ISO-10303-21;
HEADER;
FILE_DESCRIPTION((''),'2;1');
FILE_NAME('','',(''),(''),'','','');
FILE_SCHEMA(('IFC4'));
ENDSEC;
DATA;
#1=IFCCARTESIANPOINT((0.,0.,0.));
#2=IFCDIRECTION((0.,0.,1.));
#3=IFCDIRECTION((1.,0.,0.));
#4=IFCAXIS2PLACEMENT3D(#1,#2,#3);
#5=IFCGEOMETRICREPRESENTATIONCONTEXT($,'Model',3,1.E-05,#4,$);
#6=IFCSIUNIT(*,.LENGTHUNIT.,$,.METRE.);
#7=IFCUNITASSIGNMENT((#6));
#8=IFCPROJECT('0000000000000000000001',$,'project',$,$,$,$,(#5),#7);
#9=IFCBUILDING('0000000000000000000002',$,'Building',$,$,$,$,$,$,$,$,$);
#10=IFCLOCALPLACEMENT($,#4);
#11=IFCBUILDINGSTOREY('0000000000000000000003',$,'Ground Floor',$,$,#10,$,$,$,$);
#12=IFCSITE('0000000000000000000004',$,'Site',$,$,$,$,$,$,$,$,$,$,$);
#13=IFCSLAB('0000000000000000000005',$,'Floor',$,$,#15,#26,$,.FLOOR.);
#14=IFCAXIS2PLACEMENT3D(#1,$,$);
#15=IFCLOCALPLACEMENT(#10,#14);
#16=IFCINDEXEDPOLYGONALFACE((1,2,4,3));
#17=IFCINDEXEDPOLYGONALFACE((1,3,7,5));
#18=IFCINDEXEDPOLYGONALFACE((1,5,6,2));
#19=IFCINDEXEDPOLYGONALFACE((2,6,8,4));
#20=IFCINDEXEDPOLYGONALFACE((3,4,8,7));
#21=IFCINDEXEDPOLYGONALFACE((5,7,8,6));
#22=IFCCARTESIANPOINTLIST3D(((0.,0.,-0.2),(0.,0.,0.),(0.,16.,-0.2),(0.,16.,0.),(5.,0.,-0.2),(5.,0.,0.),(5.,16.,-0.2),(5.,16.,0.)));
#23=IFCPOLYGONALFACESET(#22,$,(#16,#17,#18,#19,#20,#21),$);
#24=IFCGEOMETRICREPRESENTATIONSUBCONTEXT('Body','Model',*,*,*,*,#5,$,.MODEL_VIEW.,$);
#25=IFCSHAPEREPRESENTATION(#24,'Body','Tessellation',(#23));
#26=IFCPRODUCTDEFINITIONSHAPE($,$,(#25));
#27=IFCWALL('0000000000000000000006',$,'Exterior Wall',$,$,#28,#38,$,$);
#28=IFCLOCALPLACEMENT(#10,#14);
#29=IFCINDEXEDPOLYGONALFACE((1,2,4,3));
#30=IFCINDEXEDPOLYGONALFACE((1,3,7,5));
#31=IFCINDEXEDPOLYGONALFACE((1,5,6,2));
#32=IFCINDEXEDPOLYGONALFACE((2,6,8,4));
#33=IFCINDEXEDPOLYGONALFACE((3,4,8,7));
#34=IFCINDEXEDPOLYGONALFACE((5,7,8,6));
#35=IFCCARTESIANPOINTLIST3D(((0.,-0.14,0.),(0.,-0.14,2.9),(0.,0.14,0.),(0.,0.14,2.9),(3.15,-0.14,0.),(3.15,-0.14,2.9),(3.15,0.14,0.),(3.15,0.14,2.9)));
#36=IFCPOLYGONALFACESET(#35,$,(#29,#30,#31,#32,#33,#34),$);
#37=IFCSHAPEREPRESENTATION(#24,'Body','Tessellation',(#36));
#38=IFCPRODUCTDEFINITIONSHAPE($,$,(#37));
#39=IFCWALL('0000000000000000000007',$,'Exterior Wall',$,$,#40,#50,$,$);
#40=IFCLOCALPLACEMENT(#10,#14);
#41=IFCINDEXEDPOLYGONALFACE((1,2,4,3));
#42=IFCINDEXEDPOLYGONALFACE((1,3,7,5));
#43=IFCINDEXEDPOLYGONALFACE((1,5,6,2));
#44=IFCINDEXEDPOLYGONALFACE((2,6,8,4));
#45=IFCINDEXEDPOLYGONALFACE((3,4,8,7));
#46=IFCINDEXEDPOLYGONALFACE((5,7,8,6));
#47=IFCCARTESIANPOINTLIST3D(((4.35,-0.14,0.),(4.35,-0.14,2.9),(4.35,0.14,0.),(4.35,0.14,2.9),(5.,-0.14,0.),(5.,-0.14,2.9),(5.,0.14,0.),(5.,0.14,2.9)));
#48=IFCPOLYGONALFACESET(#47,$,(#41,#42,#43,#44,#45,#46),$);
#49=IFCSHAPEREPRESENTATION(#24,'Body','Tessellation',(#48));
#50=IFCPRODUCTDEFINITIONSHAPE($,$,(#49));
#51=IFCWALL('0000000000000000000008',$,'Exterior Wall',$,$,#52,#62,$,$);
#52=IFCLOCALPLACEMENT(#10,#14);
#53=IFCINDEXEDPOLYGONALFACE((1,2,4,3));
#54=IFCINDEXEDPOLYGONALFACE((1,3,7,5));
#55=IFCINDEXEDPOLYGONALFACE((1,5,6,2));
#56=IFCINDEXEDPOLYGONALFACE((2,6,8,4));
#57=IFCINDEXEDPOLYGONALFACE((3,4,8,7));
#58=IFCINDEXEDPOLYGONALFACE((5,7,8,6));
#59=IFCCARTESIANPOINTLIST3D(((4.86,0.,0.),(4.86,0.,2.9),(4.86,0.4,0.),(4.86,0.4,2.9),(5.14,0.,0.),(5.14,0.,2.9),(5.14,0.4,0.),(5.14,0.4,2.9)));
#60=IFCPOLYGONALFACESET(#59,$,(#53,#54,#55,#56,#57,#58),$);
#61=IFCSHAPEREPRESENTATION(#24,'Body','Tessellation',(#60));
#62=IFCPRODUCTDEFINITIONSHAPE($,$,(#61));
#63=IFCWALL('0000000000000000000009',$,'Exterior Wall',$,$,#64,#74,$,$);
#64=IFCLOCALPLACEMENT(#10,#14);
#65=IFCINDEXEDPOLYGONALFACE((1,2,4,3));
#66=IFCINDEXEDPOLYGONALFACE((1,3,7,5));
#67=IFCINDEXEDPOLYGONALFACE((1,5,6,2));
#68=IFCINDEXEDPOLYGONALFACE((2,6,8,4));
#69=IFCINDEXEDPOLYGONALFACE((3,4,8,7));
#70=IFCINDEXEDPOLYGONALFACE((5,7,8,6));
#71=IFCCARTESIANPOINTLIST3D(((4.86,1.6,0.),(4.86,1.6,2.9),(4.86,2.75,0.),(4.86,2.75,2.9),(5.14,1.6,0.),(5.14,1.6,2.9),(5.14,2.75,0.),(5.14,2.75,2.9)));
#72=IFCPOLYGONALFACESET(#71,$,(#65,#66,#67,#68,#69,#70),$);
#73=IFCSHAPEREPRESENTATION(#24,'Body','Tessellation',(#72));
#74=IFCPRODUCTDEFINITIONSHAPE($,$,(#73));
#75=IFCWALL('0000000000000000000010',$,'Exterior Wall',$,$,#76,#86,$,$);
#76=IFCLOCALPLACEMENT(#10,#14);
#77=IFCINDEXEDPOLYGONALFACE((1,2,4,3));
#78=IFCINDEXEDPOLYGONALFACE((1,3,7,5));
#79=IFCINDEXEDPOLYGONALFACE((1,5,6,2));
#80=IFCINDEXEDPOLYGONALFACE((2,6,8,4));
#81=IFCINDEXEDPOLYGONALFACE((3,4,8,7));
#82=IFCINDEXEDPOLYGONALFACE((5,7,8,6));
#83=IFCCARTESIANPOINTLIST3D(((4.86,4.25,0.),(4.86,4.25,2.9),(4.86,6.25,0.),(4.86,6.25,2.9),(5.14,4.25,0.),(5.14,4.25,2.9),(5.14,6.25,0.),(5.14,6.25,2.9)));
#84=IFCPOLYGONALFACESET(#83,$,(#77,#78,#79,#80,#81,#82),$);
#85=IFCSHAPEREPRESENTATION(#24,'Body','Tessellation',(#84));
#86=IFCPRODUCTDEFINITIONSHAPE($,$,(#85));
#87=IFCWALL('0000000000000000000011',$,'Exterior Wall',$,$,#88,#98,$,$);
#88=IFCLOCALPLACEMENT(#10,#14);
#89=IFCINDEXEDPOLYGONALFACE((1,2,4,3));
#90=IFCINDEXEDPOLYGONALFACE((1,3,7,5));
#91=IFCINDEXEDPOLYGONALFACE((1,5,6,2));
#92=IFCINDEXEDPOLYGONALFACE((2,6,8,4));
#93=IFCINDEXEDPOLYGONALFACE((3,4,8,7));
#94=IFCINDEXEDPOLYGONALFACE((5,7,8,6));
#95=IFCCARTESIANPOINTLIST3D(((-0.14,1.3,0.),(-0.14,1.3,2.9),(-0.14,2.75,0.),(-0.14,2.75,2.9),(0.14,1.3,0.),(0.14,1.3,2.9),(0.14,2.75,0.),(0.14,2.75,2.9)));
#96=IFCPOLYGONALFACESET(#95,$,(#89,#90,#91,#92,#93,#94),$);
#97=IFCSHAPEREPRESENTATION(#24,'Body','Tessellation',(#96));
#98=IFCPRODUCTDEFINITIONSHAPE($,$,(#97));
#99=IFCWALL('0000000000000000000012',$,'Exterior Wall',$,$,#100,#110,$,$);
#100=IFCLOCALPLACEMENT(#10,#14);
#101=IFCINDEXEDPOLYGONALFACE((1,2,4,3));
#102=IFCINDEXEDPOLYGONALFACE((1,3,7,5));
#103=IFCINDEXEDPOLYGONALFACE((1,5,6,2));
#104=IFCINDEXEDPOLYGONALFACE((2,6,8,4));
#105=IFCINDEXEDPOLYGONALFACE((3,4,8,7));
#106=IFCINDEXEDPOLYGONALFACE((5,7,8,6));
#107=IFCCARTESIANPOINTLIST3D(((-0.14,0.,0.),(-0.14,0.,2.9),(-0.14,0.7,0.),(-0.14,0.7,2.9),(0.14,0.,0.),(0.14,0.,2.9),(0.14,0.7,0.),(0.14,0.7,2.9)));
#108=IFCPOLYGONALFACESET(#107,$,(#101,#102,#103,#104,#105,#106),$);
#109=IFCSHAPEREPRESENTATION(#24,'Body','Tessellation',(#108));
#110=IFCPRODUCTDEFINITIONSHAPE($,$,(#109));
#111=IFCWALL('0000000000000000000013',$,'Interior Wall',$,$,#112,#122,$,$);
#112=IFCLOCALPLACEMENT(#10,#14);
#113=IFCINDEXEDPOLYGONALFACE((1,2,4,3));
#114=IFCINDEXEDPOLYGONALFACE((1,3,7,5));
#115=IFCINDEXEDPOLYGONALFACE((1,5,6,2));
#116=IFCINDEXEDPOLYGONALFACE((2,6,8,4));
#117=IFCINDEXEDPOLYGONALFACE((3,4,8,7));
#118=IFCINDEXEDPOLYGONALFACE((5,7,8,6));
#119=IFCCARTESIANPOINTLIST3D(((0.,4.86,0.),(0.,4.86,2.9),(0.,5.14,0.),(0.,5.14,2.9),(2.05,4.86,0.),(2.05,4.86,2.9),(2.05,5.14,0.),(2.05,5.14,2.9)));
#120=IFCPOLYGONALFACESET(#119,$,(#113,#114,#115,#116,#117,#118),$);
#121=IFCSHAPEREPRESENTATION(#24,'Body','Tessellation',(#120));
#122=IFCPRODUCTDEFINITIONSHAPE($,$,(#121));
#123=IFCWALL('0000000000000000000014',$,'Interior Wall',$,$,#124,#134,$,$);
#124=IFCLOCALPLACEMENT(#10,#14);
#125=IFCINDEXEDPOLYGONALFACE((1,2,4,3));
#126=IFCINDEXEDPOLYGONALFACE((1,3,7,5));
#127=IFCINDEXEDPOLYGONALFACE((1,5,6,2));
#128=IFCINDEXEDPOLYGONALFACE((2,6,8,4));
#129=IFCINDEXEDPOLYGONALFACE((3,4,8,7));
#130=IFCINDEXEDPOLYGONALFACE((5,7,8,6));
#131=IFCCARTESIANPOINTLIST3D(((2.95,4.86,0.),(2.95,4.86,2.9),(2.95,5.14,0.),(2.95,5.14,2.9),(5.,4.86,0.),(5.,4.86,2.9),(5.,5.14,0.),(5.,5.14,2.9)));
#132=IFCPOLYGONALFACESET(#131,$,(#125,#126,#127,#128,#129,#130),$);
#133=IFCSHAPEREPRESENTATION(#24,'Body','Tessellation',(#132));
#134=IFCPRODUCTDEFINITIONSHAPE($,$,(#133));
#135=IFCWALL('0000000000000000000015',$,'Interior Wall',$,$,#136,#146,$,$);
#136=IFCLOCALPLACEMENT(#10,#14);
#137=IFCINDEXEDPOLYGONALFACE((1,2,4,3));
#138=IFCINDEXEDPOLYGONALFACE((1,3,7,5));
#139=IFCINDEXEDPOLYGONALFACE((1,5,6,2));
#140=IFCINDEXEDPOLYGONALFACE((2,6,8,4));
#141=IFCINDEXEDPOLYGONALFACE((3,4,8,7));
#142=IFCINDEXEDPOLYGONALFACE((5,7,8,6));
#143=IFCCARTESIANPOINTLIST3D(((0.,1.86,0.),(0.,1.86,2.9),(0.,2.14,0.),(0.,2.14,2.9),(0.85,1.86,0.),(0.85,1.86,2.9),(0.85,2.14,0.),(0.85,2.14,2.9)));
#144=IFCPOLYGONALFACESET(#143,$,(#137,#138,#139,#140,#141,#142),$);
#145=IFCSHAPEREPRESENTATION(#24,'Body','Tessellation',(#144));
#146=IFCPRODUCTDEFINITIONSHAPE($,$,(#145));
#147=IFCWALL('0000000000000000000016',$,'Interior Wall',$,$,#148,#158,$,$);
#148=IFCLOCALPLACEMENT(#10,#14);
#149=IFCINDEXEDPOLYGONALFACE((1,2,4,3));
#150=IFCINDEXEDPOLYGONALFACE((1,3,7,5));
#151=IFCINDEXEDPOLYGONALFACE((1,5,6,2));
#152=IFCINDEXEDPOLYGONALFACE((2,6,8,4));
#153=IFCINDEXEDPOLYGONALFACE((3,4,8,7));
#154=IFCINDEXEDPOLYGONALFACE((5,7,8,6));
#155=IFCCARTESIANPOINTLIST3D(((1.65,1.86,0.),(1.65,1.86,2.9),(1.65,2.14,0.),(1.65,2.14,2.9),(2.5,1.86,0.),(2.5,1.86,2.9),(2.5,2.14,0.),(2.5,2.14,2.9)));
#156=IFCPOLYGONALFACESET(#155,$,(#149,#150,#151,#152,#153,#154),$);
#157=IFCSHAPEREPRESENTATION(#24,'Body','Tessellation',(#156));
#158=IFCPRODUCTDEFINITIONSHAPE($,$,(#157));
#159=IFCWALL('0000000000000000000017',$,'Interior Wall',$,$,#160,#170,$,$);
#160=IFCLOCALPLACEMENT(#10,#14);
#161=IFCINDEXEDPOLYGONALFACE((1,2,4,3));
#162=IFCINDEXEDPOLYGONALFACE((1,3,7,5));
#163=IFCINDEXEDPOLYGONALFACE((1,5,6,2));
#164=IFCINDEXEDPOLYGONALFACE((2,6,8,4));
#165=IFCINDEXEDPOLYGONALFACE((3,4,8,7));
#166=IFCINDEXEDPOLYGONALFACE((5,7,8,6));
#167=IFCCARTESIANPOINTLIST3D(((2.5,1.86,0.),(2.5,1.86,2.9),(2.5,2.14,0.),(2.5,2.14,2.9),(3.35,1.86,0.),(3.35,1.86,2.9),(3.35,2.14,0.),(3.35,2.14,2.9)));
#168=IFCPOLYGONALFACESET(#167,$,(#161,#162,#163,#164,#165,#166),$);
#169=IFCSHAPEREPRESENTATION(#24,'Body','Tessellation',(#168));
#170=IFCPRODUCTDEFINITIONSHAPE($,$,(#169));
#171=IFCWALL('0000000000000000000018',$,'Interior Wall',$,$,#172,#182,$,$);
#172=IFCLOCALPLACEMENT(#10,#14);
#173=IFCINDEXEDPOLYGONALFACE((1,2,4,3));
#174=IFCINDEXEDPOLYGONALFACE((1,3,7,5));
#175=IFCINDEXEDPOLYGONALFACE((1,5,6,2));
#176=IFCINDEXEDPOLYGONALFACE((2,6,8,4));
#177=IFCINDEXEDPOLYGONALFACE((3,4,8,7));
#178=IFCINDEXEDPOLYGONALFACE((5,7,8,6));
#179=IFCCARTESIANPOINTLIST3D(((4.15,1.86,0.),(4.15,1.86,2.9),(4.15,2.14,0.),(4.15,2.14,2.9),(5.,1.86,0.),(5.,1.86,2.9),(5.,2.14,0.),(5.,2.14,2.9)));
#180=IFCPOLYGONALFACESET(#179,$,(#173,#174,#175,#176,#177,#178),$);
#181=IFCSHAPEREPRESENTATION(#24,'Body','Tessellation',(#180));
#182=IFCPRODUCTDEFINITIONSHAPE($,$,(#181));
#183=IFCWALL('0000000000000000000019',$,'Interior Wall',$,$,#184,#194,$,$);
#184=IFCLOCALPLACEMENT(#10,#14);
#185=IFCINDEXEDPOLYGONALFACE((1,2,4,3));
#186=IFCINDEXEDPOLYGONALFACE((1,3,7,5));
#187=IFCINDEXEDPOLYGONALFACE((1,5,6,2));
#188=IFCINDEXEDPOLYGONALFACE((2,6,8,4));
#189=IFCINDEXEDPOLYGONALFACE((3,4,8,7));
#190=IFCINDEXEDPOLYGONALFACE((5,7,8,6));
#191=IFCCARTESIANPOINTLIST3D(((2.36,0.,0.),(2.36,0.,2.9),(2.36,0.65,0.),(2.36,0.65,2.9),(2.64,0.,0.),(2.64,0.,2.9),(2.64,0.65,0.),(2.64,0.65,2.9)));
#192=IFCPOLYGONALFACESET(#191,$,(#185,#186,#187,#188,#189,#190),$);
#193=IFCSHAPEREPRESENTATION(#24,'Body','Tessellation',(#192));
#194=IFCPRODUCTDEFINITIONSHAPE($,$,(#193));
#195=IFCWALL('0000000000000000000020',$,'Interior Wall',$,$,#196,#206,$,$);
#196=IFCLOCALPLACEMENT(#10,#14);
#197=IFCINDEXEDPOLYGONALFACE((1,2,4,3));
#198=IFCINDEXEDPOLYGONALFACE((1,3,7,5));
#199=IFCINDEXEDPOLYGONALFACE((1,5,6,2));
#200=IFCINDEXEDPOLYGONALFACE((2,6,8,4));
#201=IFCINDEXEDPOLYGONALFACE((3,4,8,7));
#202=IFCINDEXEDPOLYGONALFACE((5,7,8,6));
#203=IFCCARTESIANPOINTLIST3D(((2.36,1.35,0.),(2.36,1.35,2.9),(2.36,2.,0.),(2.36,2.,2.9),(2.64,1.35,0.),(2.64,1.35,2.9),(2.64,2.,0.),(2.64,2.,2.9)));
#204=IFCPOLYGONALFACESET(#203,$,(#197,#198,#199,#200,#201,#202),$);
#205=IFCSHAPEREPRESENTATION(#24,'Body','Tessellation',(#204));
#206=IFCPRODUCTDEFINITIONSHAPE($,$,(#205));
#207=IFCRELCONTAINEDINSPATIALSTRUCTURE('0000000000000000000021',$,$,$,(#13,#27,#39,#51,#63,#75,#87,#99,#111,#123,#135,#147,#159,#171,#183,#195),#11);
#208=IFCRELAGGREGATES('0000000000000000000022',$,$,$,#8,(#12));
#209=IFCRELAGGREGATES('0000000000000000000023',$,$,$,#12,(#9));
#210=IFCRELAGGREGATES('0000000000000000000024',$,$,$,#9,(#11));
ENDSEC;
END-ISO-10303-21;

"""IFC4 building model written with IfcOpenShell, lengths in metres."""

from ifc_helpers import new_model, si_unit, frame, origin_with_axes, place, context, subcontext, project, spatial, indexed_curve, outline, extrude, element, save


model = new_model("IFC4")

# Units and contexts
model_context = context("Model", 3, precision=1e-05, world=origin_with_axes())
body_context = subcontext(model_context, "Body", "Model", "MODEL_VIEW")
ifc_project = project(units=[si_unit("LENGTHUNIT", "METRE")], contexts=[model_context])

# Site, building, storey
site = spatial("IfcSite", under=ifc_project, Name="Site")
building = spatial("IfcBuilding", under=site, Name="Building")
storey_placement = place(None, origin_with_axes())
storey = spatial("IfcBuildingStorey", under=building, at=storey_placement, Name="Ground Floor")

# Slab
slab_placement = place(storey_placement, frame((0.0, 0.0, -0.2), z_axis=(0.0, 0.0, 1.0), x_axis=(1.0, 0.0, 0.0)))
element("IfcSlab", 1, at=slab_placement, inside=storey, Name="Floor", PredefinedType="FLOOR", context=body_context, shape_type="SweptSolid", body=[
    extrude(outline(indexed_curve([(0.0, 0.0), (5.0, 0.0), (5.0, 16.0), (0.0, 16.0)])), None, (0.0, 0.0, 1.0), 0.2),
])

# Walls
wall_1_placement = place(storey_placement, origin_with_axes())
element("IfcWall", 2, at=wall_1_placement, inside=storey, Name="Exterior Wall", context=body_context, shape_type="SweptSolid", body=[
    extrude(outline(indexed_curve([(0.0, 0.0), (0.0, 0.28), (3.15, 0.28), (3.15, 0.0), (0.0, 0.0)], self_intersect=False)), frame((0.0, -0.14, 0.0), z_axis=(0.0, 0.0, 1.0), x_axis=(1.0, 0.0, 0.0)), (0.0, 0.0, 1.0), 2.9),
])
wall_2_placement = place(storey_placement, frame((4.35, 0.0, 0.0), z_axis=(0.0, 0.0, 1.0), x_axis=(1.0, 0.0, 0.0)))
element("IfcWall", 3, at=wall_2_placement, inside=storey, Name="Exterior Wall", context=body_context, shape_type="SweptSolid", body=[
    extrude(outline(indexed_curve([(0.0, 0.0), (0.0, 0.28), (0.65, 0.28), (0.65, 0.0), (0.0, 0.0)], self_intersect=False)), frame((0.0, -0.14, 0.0), z_axis=(0.0, 0.0, 1.0), x_axis=(1.0, 0.0, 0.0)), (0.0, 0.0, 1.0), 2.9),
])
wall_3_placement = place(storey_placement, frame((5.0, 0.0, 0.0), z_axis=(0.0, 0.0, 1.0), x_axis=(0.0, 1.0, 0.0)))
element("IfcWall", 4, at=wall_3_placement, inside=storey, Name="Exterior Wall", context=body_context, shape_type="SweptSolid", body=[
    extrude(outline(indexed_curve([(0.0, 0.0), (0.0, 0.28), (0.4, 0.28), (0.4, 0.0), (0.0, 0.0)], self_intersect=False)), frame((0.0, -0.14, 0.0), z_axis=(0.0, 0.0, 1.0), x_axis=(1.0, 0.0, 0.0)), (0.0, 0.0, 1.0), 2.9),
])
wall_4_placement = place(storey_placement, frame((5.0, 1.6, 0.0), z_axis=(0.0, 0.0, 1.0), x_axis=(0.0, 1.0, 0.0)))
element("IfcWall", 5, at=wall_4_placement, inside=storey, Name="Exterior Wall", context=body_context, shape_type="SweptSolid", body=[
    extrude(outline(indexed_curve([(0.0, 0.0), (0.0, 0.28), (1.15, 0.28), (1.15, 0.0), (0.0, 0.0)], self_intersect=False)), frame((0.0, -0.14, 0.0), z_axis=(0.0, 0.0, 1.0), x_axis=(1.0, 0.0, 0.0)), (0.0, 0.0, 1.0), 2.9),
])
wall_5_placement = place(storey_placement, frame((5.0, 4.25, 0.0), z_axis=(0.0, 0.0, 1.0), x_axis=(0.0, 1.0, 0.0)))
element("IfcWall", 6, at=wall_5_placement, inside=storey, Name="Exterior Wall", context=body_context, shape_type="SweptSolid", body=[
    extrude(outline(indexed_curve([(0.0, 0.0), (0.0, 0.28), (2.0, 0.28), (2.0, 0.0), (0.0, 0.0)], self_intersect=False)), frame((0.0, -0.14, 0.0), z_axis=(0.0, 0.0, 1.0), x_axis=(1.0, 0.0, 0.0)), (0.0, 0.0, 1.0), 2.9),
])
wall_6_placement = place(storey_placement, frame((0.0, 2.75, 0.0), z_axis=(0.0, 0.0, 1.0), x_axis=(0.0, -1.0, 0.0)))
element("IfcWall", 7, at=wall_6_placement, inside=storey, Name="Exterior Wall", context=body_context, shape_type="SweptSolid", body=[
    extrude(outline(indexed_curve([(0.0, 0.0), (0.0, 0.28), (1.45, 0.28), (1.45, 0.0), (0.0, 0.0)], self_intersect=False)), frame((0.0, -0.14, 0.0), z_axis=(0.0, 0.0, 1.0), x_axis=(1.0, 0.0, 0.0)), (0.0, 0.0, 1.0), 2.9),
])
wall_7_placement = place(storey_placement, frame((0.0, 0.7, 0.0), z_axis=(0.0, 0.0, 1.0), x_axis=(0.0, -1.0, 0.0)))
element("IfcWall", 8, at=wall_7_placement, inside=storey, Name="Exterior Wall", context=body_context, shape_type="SweptSolid", body=[
    extrude(outline(indexed_curve([(0.0, 0.0), (0.0, 0.28), (0.7, 0.28), (0.7, 0.0), (0.0, 0.0)], self_intersect=False)), frame((0.0, -0.14, 0.0), z_axis=(0.0, 0.0, 1.0), x_axis=(1.0, 0.0, 0.0)), (0.0, 0.0, 1.0), 2.9),
])
for number, where, z_axis, x_axis, name in (
    (9, (0.0, 5.0, 0.0), (0.0, 0.0, 1.0), (1.0, 0.0, 0.0), "Interior Wall"),
    (10, (2.95, 5.0, 0.0), (0.0, 0.0, 1.0), (1.0, 0.0, 0.0), "Interior Wall"),
):
    element("IfcWall", number, at=place(storey_placement, frame(where, z_axis=z_axis, x_axis=x_axis)), inside=storey, Name=name, context=body_context, shape_type="SweptSolid", body=[
        extrude(outline(indexed_curve([(0.0, 0.0), (0.0, 0.28), (2.05, 0.28), (2.05, 0.0), (0.0, 0.0)], self_intersect=False)), frame((0.0, -0.14, 0.0), z_axis=(0.0, 0.0, 1.0), x_axis=(1.0, 0.0, 0.0)), (0.0, 0.0, 1.0), 2.9),
    ])
wall_8_placement = place(storey_placement, frame((0.0, 2.0, 0.0), z_axis=(0.0, 0.0, 1.0), x_axis=(1.0, 0.0, 0.0)))
element("IfcWall", 11, at=wall_8_placement, inside=storey, Name="Interior Wall", context=body_context, shape_type="SweptSolid", body=[
    extrude(outline(indexed_curve([(0.0, 0.0), (0.0, 0.28), (0.85, 0.28), (0.85, 0.0), (0.0, 0.0)], self_intersect=False)), frame((0.0, -0.14, 0.0), z_axis=(0.0, 0.0, 1.0), x_axis=(1.0, 0.0, 0.0)), (0.0, 0.0, 1.0), 2.9),
])
for number, where, z_axis, x_axis, name in (
    (12, (1.65, 2.0, 0.0), (0.0, 0.0, 1.0), (1.0, 0.0, 0.0), "Interior Wall"),
    (13, (2.5, 2.0, 0.0), (0.0, 0.0, 1.0), (1.0, 0.0, 0.0), "Interior Wall"),
):
    element("IfcWall", number, at=place(storey_placement, frame(where, z_axis=z_axis, x_axis=x_axis)), inside=storey, Name=name, context=body_context, shape_type="SweptSolid", body=[
        extrude(outline(indexed_curve([(0.0, 0.0), (0.0, 0.28), (0.85, 0.28), (0.85, 0.0), (0.0, 0.0)], self_intersect=False)), frame((0.0, -0.14, 0.0), z_axis=(0.0, 0.0, 1.0), x_axis=(1.0, 0.0, 0.0)), (0.0, 0.0, 1.0), 2.9),
    ])
wall_9_placement = place(storey_placement, frame((4.15, 2.0, 0.0), z_axis=(0.0, 0.0, 1.0), x_axis=(1.0, 0.0, 0.0)))
element("IfcWall", 14, at=wall_9_placement, inside=storey, Name="Interior Wall", context=body_context, shape_type="SweptSolid", body=[
    extrude(outline(indexed_curve([(0.0, 0.0), (0.0, 0.28), (0.85, 0.28), (0.85, 0.0), (0.0, 0.0)], self_intersect=False)), frame((0.0, -0.14, 0.0), z_axis=(0.0, 0.0, 1.0), x_axis=(1.0, 0.0, 0.0)), (0.0, 0.0, 1.0), 2.9),
])
wall_10_placement = place(storey_placement, frame((2.5, 0.0, 0.0), z_axis=(0.0, 0.0, 1.0), x_axis=(0.0, 1.0, 0.0)))
element("IfcWall", 15, at=wall_10_placement, inside=storey, Name="Interior Wall", context=body_context, shape_type="SweptSolid", body=[
    extrude(outline(indexed_curve([(0.0, 0.0), (0.0, 0.28), (0.65, 0.28), (0.65, 0.0), (0.0, 0.0)], self_intersect=False)), frame((0.0, -0.14, 0.0), z_axis=(0.0, 0.0, 1.0), x_axis=(1.0, 0.0, 0.0)), (0.0, 0.0, 1.0), 2.9),
])
wall_11_placement = place(storey_placement, frame((2.5, 1.35, 0.0), z_axis=(0.0, 0.0, 1.0), x_axis=(0.0, 1.0, 0.0)))
element("IfcWall", 16, at=wall_11_placement, inside=storey, Name="Interior Wall", context=body_context, shape_type="SweptSolid", body=[
    extrude(outline(indexed_curve([(0.0, 0.0), (0.0, 0.28), (0.65, 0.28), (0.65, 0.0), (0.0, 0.0)], self_intersect=False)), frame((0.0, -0.14, 0.0), z_axis=(0.0, 0.0, 1.0), x_axis=(1.0, 0.0, 0.0)), (0.0, 0.0, 1.0), 2.9),
])

save(model, "model.ifc")
